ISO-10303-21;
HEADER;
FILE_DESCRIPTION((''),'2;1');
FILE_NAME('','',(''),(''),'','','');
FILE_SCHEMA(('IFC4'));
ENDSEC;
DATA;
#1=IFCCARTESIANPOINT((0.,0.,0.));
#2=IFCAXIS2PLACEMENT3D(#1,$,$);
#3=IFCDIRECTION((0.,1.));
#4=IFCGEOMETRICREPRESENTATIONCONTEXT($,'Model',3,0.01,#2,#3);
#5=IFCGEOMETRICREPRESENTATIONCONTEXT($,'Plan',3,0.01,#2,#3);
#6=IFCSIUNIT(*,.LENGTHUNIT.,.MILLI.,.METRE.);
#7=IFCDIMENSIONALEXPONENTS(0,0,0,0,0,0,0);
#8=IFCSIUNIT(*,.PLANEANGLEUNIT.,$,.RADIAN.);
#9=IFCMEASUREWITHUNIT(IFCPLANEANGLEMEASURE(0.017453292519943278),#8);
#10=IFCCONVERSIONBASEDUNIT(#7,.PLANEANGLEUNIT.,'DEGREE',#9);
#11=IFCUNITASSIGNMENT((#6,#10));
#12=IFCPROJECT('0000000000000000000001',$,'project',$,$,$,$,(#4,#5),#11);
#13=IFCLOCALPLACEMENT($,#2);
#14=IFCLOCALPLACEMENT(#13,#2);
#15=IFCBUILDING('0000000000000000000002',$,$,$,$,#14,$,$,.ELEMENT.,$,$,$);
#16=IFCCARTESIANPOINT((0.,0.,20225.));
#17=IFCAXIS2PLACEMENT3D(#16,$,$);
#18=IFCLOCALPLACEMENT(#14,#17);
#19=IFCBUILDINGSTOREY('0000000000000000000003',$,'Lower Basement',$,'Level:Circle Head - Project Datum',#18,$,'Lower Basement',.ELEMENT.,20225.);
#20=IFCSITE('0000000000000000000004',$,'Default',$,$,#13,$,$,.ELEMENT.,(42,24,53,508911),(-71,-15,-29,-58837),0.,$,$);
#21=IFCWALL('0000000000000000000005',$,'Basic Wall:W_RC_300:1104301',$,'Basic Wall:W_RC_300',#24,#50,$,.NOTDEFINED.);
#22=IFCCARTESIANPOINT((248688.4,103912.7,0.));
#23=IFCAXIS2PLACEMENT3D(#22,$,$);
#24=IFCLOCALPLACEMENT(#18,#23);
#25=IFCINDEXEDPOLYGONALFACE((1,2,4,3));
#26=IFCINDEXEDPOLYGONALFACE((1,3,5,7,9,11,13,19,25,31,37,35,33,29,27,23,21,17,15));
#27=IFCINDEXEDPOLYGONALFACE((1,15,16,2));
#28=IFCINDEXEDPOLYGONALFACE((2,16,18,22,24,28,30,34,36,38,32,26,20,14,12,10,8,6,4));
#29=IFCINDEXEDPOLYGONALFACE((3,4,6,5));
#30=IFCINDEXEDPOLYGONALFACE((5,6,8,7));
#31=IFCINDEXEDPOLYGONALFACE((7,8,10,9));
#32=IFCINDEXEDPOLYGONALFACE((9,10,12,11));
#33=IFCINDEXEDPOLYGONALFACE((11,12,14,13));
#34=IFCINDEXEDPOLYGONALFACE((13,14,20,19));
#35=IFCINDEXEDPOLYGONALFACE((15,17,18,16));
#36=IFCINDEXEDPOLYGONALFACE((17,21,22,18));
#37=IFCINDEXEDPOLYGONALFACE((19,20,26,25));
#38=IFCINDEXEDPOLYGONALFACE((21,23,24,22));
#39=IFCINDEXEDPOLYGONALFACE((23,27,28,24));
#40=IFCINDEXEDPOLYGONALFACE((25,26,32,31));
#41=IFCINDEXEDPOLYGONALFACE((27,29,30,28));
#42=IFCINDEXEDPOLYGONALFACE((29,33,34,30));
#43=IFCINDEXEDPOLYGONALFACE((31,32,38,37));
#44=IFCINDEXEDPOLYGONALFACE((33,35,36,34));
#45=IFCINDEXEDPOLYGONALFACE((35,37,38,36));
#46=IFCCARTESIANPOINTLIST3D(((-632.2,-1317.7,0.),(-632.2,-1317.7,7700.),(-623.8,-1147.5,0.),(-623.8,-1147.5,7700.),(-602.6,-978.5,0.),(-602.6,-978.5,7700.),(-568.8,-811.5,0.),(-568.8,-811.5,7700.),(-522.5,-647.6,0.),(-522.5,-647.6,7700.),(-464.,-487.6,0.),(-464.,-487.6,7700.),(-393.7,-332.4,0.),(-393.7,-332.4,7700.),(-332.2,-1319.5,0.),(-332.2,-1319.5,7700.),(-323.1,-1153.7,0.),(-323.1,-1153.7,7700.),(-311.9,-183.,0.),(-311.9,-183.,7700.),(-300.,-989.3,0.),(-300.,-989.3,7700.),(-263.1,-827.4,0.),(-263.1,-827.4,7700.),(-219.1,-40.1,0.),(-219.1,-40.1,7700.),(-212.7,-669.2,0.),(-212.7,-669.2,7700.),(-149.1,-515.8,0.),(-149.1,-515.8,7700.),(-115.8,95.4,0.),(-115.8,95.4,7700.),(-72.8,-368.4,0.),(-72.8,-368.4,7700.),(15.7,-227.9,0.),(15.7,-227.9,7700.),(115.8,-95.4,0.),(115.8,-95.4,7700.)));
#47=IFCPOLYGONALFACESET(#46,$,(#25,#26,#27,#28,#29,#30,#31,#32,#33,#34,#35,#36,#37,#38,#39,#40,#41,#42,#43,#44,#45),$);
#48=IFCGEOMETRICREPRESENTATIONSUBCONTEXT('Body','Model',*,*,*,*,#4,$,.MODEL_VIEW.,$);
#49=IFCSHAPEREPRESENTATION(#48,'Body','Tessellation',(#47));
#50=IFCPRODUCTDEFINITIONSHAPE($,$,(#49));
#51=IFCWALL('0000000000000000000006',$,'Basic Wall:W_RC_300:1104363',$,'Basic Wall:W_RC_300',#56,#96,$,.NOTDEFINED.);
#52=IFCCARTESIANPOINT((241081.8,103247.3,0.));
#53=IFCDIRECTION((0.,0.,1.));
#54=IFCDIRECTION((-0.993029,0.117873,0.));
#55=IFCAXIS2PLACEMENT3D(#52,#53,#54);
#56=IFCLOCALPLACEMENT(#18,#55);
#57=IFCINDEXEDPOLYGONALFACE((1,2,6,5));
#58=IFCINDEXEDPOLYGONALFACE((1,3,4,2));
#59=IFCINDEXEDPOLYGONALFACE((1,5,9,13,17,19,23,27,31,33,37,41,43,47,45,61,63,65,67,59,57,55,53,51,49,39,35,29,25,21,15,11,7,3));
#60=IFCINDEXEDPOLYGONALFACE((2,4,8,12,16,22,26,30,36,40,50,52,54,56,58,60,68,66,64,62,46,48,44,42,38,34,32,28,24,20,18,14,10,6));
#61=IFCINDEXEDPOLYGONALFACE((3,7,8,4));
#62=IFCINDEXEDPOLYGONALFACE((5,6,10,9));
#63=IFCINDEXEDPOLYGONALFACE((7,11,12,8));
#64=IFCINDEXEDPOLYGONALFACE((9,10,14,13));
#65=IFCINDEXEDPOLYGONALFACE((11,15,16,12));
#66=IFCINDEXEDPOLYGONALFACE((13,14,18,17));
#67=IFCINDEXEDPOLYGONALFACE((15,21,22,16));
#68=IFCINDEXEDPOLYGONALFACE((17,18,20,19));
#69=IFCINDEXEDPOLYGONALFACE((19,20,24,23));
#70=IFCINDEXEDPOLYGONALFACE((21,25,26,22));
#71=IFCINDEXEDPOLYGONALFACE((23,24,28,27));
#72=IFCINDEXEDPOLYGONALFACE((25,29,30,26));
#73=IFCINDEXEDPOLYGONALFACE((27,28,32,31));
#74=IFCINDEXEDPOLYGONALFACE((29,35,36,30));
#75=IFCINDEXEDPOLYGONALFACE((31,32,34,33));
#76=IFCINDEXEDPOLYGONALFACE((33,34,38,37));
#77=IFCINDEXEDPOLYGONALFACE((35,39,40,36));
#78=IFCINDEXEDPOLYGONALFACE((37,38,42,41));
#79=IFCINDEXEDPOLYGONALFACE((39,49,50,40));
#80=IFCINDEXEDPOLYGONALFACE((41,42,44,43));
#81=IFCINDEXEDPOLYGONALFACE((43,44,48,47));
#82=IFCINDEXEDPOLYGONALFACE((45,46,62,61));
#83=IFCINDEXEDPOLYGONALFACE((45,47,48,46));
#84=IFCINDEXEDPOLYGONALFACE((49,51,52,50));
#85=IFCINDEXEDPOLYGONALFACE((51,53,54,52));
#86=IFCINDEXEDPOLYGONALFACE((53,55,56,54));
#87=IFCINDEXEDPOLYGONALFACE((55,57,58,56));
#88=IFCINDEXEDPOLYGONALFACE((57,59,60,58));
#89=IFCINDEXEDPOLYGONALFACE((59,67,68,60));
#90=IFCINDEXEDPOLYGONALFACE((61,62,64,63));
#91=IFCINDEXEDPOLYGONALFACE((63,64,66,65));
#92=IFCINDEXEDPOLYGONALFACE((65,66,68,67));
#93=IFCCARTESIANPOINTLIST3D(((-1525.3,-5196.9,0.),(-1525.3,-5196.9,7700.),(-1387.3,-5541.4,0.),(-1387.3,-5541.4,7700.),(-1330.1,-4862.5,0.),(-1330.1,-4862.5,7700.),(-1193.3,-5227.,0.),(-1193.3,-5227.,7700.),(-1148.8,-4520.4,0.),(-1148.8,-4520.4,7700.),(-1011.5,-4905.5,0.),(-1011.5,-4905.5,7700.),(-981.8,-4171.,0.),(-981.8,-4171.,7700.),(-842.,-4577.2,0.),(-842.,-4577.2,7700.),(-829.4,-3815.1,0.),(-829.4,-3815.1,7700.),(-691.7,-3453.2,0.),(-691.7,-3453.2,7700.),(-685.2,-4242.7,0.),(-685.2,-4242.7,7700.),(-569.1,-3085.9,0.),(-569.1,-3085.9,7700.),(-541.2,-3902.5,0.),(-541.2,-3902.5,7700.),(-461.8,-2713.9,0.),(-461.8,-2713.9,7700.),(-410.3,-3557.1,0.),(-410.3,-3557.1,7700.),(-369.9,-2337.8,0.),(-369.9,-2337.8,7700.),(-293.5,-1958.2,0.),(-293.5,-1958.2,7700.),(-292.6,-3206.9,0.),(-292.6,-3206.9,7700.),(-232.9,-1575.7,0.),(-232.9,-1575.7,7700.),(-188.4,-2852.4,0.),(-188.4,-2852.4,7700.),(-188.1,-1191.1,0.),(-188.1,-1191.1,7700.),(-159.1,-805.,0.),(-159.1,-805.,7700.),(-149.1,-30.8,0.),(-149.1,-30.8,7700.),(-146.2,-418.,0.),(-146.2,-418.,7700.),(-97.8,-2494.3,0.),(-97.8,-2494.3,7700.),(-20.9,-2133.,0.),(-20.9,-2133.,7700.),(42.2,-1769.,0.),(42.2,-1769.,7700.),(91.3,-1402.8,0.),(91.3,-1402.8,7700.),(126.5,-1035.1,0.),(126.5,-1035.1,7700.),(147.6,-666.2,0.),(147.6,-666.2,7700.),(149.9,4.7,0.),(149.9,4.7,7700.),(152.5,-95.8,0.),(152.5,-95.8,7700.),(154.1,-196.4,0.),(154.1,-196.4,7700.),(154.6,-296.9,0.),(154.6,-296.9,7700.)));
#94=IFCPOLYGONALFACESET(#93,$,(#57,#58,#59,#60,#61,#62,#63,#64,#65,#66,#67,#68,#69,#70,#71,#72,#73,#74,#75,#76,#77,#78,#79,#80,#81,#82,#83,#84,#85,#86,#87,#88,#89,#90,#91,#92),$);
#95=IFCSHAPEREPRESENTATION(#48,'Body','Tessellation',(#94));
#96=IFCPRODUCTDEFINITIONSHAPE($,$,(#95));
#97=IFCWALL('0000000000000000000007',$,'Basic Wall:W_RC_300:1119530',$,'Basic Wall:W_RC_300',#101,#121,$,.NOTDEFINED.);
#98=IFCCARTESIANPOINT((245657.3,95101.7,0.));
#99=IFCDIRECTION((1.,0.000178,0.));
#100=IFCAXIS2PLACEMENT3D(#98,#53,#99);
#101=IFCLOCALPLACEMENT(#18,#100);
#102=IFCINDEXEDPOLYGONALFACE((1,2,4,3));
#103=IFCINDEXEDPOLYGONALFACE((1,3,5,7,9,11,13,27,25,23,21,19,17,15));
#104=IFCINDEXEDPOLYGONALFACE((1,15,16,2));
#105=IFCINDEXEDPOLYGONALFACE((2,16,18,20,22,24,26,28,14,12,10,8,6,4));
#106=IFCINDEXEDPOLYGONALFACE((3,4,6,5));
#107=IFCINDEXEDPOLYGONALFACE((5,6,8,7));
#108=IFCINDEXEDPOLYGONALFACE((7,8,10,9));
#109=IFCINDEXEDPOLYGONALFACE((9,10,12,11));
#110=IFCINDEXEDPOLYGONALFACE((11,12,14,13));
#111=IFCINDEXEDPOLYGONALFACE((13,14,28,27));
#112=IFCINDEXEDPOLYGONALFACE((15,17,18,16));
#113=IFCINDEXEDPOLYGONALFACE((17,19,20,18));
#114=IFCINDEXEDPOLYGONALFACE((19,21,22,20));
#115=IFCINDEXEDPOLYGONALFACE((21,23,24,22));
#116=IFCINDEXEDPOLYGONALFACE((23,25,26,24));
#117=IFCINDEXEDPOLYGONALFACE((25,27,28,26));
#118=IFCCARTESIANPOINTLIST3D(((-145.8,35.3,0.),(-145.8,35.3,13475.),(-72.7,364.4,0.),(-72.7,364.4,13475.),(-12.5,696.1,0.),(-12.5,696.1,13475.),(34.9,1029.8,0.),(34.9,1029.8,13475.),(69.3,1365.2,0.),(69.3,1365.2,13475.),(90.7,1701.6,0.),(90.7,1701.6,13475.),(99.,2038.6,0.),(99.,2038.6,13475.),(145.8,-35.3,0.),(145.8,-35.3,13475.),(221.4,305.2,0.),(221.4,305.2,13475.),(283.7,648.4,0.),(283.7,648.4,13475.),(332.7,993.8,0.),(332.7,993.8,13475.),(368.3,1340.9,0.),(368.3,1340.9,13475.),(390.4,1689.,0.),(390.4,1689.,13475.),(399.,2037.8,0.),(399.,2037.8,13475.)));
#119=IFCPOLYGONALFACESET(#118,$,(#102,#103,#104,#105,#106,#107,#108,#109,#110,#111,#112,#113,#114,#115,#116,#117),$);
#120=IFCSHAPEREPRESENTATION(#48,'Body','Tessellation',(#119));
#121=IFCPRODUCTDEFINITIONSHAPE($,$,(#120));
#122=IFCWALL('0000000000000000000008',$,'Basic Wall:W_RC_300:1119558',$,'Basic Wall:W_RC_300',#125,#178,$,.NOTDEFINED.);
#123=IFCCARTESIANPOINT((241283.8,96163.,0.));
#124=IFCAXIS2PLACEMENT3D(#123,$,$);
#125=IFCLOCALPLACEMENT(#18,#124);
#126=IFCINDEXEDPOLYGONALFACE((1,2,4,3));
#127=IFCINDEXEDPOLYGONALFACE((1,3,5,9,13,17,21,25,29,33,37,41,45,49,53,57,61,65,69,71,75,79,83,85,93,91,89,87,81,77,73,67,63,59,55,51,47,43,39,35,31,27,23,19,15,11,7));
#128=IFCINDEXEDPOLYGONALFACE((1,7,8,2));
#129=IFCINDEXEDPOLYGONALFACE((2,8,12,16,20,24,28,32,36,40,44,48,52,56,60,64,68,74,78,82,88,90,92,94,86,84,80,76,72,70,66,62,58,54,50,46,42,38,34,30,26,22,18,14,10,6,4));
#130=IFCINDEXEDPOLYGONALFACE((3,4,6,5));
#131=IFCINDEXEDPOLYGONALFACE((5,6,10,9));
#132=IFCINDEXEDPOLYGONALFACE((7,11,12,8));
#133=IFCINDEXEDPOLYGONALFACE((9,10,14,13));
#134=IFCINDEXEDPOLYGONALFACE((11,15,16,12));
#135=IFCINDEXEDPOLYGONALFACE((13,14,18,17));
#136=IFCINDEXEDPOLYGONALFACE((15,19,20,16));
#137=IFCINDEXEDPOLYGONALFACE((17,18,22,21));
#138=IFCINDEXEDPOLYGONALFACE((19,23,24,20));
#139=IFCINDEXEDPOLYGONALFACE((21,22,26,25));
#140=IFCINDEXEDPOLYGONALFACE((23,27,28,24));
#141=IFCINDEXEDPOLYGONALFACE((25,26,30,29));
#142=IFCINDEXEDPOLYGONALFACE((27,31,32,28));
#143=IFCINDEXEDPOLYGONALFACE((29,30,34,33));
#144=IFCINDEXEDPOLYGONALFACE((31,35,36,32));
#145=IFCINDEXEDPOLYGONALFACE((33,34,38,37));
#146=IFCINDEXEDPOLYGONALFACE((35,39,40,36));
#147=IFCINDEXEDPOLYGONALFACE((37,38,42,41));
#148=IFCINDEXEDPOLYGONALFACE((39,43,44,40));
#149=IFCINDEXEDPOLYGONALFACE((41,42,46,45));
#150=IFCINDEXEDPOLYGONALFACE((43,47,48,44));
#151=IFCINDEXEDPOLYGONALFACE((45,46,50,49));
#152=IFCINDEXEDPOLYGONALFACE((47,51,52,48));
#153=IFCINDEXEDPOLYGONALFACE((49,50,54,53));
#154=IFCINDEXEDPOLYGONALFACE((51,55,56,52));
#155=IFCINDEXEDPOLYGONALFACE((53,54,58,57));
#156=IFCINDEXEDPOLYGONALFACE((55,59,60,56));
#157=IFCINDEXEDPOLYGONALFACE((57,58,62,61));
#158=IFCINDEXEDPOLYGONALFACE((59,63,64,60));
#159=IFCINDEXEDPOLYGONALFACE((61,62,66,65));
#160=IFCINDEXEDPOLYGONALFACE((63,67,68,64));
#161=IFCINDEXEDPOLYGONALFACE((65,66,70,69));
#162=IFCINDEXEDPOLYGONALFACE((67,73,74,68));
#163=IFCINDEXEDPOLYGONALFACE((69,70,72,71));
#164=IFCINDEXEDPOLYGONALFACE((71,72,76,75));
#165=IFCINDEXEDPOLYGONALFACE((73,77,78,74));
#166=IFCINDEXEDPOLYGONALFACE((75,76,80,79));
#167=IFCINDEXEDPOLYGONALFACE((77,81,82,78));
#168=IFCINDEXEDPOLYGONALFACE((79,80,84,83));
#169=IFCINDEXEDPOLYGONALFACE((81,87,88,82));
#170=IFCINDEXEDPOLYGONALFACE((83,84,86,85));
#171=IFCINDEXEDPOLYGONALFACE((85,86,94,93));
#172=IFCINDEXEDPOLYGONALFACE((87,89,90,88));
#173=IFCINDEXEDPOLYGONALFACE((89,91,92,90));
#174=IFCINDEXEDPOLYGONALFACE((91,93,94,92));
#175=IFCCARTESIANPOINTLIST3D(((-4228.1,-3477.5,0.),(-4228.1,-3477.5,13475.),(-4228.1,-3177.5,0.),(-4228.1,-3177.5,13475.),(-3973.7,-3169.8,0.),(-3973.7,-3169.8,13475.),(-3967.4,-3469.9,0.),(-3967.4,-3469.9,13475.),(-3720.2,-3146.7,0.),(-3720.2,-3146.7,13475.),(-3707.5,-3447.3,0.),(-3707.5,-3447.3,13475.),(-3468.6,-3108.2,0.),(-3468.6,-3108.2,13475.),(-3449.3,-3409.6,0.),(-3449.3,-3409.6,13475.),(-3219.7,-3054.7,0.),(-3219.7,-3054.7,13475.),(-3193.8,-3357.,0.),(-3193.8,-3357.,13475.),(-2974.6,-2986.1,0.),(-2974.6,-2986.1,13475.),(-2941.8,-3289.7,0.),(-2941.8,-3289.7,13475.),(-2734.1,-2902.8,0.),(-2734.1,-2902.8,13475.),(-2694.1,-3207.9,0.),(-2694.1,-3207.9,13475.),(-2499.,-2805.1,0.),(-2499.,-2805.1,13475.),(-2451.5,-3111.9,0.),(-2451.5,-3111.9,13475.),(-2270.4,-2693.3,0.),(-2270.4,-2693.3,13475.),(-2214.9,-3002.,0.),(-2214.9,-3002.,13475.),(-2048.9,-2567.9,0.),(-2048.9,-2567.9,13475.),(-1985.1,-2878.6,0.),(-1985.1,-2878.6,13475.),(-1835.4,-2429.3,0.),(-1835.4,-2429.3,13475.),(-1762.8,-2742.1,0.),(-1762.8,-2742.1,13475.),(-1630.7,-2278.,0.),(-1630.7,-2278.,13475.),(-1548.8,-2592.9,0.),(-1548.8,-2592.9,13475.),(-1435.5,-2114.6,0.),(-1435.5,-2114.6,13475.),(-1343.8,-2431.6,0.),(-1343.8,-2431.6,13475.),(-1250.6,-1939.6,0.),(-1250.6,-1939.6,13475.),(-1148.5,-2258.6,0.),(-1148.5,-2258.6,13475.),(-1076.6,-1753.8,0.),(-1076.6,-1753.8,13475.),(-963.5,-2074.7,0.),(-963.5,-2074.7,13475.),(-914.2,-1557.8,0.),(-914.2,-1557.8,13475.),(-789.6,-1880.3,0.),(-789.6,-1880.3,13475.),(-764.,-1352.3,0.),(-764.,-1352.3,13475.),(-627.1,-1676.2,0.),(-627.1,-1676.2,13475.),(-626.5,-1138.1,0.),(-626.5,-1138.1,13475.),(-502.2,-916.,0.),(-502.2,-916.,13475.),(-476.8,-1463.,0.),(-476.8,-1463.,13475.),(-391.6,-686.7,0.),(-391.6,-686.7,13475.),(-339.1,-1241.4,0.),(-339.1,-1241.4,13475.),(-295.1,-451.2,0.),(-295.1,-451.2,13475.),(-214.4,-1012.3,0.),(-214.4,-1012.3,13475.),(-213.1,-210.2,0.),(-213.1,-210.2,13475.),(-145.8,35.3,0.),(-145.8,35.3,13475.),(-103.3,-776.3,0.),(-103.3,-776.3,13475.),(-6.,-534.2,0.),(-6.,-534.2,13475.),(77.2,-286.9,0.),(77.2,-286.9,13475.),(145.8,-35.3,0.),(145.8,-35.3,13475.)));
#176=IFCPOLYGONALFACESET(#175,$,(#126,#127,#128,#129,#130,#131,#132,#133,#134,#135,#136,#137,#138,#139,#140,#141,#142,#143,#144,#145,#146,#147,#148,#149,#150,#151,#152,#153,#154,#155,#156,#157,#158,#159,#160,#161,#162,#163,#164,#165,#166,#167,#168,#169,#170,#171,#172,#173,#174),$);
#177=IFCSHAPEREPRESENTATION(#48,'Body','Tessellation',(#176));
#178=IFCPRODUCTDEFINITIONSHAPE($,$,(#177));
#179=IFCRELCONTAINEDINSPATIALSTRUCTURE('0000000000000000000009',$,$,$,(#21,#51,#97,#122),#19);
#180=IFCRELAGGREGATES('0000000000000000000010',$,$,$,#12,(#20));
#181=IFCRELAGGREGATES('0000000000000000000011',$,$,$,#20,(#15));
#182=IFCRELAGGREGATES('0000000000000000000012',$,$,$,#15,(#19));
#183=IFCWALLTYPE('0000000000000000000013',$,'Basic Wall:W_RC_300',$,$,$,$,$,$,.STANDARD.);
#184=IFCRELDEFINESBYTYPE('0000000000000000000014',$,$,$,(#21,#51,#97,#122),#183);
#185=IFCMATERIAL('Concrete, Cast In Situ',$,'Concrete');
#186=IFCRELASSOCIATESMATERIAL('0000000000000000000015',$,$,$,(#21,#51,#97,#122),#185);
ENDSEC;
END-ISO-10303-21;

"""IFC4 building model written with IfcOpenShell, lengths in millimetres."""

from ifc_helpers import new_model, entity, si_unit, converted_unit, direction, frame, origin, place, context, subcontext, project, spatial, line, arc, indexed_curve, outline, extrude, material, type_object, element, save


model = new_model("IFC4")

# Units and contexts
model_context = context("Model", 3, precision=0.01, world=origin(), true_north=direction((0.0, 1.0)))
plan_context = context("Plan", 3, precision=0.01, world=origin(), true_north=direction((0.0, 1.0)))
body_context = subcontext(model_context, "Body", "Model", "MODEL_VIEW")
ifc_project = project(units=[si_unit("LENGTHUNIT", "METRE", prefix="MILLI"), converted_unit("PLANEANGLEUNIT", "DEGREE", entity("IfcPlaneAngleMeasure", 0.017453292519943278), si_unit("PLANEANGLEUNIT", "RADIAN"), dimensions=[0, 0, 0, 0, 0, 0, 0])], contexts=[model_context, plan_context])

# Site, building, storey
site_placement = place(None, origin())
site = spatial("IfcSite", under=ifc_project, at=site_placement, Name="Default", CompositionType="ELEMENT", RefLatitude=(42, 24, 53, 508911), RefLongitude=(-71, -15, -29, -58837), RefElevation=0.0)
building_placement = place(site_placement, origin())
building = spatial("IfcBuilding", under=site, at=building_placement, CompositionType="ELEMENT")
storey_placement = place(building_placement, frame((0.0, 0.0, 20225.0)))
storey = spatial("IfcBuildingStorey", under=building, at=storey_placement, Name="Lower Basement", ObjectType="Level:Circle Head - Project Datum", LongName="Lower Basement", CompositionType="ELEMENT", Elevation=20225.0)

# Walls
ifc_material_1 = material(Name="Concrete, Cast In Situ", Category="Concrete")
wall_type_1 = type_object("IfcWallType", Name="Basic Wall:W_RC_300", PredefinedType="STANDARD")
wall_1_placement = place(storey_placement, frame((248688.4, 103912.7, 0.0)))
element("IfcWall", 1, at=wall_1_placement, inside=storey, type_object=wall_type_1, material=ifc_material_1, Name="Basic Wall:W_RC_300:1104301", ObjectType="Basic Wall:W_RC_300", PredefinedType="NOTDEFINED", context=body_context, shape_type="SweptSolid", body=[
    extrude(outline(indexed_curve([(-332.2, -1319.5), (-212.7, -669.2), (115.8, -95.4), (-115.8, 95.4), (-494.8, -567.0), (-632.2, -1317.7)], segments=[arc(1, 2, 3), line(3, 4), arc(4, 5, 6), line(6, 1)], self_intersect=False)), origin(), (0.0, 0.0, 1.0), 7700.0),
])
wall_2_placement = place(storey_placement, frame((241081.8, 103247.3, 0.0), z_axis=(0.0, 0.0, 1.0), x_axis=(-0.993029, 0.117873, 0.0)))
element("IfcWall", 2, at=wall_2_placement, inside=storey, type_object=wall_type_1, material=ifc_material_1, Name="Basic Wall:W_RC_300:1104363", ObjectType="Basic Wall:W_RC_300", PredefinedType="NOTDEFINED", context=body_context, shape_type="SweptSolid", body=[
    extrude(outline(indexed_curve([(-1387.3, -5541.4), (-238.9, -3030.1), (154.6, -296.9), (153.4, -146.1), (149.9, 4.7), (-149.1, -30.8), (-461.8, -2713.9), (-1525.3, -5196.9)], segments=[arc(1, 2, 3), arc(3, 4, 5), line(5, 6), arc(6, 7, 8), line(8, 1)], self_intersect=False)), origin(), (0.0, 0.0, 1.0), 7700.0),
])
wall_3_placement = place(storey_placement, frame((245657.3, 95101.7, 0.0), z_axis=(0.0, 0.0, 1.0), x_axis=(1.0, 0.000178, 0.0)))
element("IfcWall", 3, at=wall_3_placement, inside=storey, type_object=wall_type_1, material=ifc_material_1, Name="Basic Wall:W_RC_300:1119530", ObjectType="Basic Wall:W_RC_300", PredefinedType="NOTDEFINED", context=body_context, shape_type="SweptSolid", body=[
    extrude(outline(indexed_curve([(99.0, 2038.6), (34.9, 1029.8), (-145.8, 35.3), (145.8, -35.3), (332.7, 993.8), (399.0, 2037.8)], segments=[arc(1, 2, 3), line(3, 4), arc(4, 5, 6), line(6, 1)], self_intersect=False)), origin(), (0.0, 0.0, 1.0), 13475.0),
])
wall_4_placement = place(storey_placement, frame((241283.8, 96163.0, 0.0)))
element("IfcWall", 4, at=wall_4_placement, inside=storey, type_object=wall_type_1, material=ifc_material_1, Name="Basic Wall:W_RC_300:1119558", ObjectType="Basic Wall:W_RC_300", PredefinedType="NOTDEFINED", context=body_context, shape_type="SweptSolid", body=[
    extrude(outline(indexed_curve([(-4228.1, -3477.5), (-1445.1, -2513.7), (145.8, -35.3), (-145.8, 35.3), (-1630.7, -2278.0), (-4228.1, -3177.5)], segments=[arc(1, 2, 3), line(3, 4), arc(4, 5, 6), line(6, 1)], self_intersect=False)), origin(), (0.0, 0.0, 1.0), 13475.0),
])

save(model, "model.ifc")
